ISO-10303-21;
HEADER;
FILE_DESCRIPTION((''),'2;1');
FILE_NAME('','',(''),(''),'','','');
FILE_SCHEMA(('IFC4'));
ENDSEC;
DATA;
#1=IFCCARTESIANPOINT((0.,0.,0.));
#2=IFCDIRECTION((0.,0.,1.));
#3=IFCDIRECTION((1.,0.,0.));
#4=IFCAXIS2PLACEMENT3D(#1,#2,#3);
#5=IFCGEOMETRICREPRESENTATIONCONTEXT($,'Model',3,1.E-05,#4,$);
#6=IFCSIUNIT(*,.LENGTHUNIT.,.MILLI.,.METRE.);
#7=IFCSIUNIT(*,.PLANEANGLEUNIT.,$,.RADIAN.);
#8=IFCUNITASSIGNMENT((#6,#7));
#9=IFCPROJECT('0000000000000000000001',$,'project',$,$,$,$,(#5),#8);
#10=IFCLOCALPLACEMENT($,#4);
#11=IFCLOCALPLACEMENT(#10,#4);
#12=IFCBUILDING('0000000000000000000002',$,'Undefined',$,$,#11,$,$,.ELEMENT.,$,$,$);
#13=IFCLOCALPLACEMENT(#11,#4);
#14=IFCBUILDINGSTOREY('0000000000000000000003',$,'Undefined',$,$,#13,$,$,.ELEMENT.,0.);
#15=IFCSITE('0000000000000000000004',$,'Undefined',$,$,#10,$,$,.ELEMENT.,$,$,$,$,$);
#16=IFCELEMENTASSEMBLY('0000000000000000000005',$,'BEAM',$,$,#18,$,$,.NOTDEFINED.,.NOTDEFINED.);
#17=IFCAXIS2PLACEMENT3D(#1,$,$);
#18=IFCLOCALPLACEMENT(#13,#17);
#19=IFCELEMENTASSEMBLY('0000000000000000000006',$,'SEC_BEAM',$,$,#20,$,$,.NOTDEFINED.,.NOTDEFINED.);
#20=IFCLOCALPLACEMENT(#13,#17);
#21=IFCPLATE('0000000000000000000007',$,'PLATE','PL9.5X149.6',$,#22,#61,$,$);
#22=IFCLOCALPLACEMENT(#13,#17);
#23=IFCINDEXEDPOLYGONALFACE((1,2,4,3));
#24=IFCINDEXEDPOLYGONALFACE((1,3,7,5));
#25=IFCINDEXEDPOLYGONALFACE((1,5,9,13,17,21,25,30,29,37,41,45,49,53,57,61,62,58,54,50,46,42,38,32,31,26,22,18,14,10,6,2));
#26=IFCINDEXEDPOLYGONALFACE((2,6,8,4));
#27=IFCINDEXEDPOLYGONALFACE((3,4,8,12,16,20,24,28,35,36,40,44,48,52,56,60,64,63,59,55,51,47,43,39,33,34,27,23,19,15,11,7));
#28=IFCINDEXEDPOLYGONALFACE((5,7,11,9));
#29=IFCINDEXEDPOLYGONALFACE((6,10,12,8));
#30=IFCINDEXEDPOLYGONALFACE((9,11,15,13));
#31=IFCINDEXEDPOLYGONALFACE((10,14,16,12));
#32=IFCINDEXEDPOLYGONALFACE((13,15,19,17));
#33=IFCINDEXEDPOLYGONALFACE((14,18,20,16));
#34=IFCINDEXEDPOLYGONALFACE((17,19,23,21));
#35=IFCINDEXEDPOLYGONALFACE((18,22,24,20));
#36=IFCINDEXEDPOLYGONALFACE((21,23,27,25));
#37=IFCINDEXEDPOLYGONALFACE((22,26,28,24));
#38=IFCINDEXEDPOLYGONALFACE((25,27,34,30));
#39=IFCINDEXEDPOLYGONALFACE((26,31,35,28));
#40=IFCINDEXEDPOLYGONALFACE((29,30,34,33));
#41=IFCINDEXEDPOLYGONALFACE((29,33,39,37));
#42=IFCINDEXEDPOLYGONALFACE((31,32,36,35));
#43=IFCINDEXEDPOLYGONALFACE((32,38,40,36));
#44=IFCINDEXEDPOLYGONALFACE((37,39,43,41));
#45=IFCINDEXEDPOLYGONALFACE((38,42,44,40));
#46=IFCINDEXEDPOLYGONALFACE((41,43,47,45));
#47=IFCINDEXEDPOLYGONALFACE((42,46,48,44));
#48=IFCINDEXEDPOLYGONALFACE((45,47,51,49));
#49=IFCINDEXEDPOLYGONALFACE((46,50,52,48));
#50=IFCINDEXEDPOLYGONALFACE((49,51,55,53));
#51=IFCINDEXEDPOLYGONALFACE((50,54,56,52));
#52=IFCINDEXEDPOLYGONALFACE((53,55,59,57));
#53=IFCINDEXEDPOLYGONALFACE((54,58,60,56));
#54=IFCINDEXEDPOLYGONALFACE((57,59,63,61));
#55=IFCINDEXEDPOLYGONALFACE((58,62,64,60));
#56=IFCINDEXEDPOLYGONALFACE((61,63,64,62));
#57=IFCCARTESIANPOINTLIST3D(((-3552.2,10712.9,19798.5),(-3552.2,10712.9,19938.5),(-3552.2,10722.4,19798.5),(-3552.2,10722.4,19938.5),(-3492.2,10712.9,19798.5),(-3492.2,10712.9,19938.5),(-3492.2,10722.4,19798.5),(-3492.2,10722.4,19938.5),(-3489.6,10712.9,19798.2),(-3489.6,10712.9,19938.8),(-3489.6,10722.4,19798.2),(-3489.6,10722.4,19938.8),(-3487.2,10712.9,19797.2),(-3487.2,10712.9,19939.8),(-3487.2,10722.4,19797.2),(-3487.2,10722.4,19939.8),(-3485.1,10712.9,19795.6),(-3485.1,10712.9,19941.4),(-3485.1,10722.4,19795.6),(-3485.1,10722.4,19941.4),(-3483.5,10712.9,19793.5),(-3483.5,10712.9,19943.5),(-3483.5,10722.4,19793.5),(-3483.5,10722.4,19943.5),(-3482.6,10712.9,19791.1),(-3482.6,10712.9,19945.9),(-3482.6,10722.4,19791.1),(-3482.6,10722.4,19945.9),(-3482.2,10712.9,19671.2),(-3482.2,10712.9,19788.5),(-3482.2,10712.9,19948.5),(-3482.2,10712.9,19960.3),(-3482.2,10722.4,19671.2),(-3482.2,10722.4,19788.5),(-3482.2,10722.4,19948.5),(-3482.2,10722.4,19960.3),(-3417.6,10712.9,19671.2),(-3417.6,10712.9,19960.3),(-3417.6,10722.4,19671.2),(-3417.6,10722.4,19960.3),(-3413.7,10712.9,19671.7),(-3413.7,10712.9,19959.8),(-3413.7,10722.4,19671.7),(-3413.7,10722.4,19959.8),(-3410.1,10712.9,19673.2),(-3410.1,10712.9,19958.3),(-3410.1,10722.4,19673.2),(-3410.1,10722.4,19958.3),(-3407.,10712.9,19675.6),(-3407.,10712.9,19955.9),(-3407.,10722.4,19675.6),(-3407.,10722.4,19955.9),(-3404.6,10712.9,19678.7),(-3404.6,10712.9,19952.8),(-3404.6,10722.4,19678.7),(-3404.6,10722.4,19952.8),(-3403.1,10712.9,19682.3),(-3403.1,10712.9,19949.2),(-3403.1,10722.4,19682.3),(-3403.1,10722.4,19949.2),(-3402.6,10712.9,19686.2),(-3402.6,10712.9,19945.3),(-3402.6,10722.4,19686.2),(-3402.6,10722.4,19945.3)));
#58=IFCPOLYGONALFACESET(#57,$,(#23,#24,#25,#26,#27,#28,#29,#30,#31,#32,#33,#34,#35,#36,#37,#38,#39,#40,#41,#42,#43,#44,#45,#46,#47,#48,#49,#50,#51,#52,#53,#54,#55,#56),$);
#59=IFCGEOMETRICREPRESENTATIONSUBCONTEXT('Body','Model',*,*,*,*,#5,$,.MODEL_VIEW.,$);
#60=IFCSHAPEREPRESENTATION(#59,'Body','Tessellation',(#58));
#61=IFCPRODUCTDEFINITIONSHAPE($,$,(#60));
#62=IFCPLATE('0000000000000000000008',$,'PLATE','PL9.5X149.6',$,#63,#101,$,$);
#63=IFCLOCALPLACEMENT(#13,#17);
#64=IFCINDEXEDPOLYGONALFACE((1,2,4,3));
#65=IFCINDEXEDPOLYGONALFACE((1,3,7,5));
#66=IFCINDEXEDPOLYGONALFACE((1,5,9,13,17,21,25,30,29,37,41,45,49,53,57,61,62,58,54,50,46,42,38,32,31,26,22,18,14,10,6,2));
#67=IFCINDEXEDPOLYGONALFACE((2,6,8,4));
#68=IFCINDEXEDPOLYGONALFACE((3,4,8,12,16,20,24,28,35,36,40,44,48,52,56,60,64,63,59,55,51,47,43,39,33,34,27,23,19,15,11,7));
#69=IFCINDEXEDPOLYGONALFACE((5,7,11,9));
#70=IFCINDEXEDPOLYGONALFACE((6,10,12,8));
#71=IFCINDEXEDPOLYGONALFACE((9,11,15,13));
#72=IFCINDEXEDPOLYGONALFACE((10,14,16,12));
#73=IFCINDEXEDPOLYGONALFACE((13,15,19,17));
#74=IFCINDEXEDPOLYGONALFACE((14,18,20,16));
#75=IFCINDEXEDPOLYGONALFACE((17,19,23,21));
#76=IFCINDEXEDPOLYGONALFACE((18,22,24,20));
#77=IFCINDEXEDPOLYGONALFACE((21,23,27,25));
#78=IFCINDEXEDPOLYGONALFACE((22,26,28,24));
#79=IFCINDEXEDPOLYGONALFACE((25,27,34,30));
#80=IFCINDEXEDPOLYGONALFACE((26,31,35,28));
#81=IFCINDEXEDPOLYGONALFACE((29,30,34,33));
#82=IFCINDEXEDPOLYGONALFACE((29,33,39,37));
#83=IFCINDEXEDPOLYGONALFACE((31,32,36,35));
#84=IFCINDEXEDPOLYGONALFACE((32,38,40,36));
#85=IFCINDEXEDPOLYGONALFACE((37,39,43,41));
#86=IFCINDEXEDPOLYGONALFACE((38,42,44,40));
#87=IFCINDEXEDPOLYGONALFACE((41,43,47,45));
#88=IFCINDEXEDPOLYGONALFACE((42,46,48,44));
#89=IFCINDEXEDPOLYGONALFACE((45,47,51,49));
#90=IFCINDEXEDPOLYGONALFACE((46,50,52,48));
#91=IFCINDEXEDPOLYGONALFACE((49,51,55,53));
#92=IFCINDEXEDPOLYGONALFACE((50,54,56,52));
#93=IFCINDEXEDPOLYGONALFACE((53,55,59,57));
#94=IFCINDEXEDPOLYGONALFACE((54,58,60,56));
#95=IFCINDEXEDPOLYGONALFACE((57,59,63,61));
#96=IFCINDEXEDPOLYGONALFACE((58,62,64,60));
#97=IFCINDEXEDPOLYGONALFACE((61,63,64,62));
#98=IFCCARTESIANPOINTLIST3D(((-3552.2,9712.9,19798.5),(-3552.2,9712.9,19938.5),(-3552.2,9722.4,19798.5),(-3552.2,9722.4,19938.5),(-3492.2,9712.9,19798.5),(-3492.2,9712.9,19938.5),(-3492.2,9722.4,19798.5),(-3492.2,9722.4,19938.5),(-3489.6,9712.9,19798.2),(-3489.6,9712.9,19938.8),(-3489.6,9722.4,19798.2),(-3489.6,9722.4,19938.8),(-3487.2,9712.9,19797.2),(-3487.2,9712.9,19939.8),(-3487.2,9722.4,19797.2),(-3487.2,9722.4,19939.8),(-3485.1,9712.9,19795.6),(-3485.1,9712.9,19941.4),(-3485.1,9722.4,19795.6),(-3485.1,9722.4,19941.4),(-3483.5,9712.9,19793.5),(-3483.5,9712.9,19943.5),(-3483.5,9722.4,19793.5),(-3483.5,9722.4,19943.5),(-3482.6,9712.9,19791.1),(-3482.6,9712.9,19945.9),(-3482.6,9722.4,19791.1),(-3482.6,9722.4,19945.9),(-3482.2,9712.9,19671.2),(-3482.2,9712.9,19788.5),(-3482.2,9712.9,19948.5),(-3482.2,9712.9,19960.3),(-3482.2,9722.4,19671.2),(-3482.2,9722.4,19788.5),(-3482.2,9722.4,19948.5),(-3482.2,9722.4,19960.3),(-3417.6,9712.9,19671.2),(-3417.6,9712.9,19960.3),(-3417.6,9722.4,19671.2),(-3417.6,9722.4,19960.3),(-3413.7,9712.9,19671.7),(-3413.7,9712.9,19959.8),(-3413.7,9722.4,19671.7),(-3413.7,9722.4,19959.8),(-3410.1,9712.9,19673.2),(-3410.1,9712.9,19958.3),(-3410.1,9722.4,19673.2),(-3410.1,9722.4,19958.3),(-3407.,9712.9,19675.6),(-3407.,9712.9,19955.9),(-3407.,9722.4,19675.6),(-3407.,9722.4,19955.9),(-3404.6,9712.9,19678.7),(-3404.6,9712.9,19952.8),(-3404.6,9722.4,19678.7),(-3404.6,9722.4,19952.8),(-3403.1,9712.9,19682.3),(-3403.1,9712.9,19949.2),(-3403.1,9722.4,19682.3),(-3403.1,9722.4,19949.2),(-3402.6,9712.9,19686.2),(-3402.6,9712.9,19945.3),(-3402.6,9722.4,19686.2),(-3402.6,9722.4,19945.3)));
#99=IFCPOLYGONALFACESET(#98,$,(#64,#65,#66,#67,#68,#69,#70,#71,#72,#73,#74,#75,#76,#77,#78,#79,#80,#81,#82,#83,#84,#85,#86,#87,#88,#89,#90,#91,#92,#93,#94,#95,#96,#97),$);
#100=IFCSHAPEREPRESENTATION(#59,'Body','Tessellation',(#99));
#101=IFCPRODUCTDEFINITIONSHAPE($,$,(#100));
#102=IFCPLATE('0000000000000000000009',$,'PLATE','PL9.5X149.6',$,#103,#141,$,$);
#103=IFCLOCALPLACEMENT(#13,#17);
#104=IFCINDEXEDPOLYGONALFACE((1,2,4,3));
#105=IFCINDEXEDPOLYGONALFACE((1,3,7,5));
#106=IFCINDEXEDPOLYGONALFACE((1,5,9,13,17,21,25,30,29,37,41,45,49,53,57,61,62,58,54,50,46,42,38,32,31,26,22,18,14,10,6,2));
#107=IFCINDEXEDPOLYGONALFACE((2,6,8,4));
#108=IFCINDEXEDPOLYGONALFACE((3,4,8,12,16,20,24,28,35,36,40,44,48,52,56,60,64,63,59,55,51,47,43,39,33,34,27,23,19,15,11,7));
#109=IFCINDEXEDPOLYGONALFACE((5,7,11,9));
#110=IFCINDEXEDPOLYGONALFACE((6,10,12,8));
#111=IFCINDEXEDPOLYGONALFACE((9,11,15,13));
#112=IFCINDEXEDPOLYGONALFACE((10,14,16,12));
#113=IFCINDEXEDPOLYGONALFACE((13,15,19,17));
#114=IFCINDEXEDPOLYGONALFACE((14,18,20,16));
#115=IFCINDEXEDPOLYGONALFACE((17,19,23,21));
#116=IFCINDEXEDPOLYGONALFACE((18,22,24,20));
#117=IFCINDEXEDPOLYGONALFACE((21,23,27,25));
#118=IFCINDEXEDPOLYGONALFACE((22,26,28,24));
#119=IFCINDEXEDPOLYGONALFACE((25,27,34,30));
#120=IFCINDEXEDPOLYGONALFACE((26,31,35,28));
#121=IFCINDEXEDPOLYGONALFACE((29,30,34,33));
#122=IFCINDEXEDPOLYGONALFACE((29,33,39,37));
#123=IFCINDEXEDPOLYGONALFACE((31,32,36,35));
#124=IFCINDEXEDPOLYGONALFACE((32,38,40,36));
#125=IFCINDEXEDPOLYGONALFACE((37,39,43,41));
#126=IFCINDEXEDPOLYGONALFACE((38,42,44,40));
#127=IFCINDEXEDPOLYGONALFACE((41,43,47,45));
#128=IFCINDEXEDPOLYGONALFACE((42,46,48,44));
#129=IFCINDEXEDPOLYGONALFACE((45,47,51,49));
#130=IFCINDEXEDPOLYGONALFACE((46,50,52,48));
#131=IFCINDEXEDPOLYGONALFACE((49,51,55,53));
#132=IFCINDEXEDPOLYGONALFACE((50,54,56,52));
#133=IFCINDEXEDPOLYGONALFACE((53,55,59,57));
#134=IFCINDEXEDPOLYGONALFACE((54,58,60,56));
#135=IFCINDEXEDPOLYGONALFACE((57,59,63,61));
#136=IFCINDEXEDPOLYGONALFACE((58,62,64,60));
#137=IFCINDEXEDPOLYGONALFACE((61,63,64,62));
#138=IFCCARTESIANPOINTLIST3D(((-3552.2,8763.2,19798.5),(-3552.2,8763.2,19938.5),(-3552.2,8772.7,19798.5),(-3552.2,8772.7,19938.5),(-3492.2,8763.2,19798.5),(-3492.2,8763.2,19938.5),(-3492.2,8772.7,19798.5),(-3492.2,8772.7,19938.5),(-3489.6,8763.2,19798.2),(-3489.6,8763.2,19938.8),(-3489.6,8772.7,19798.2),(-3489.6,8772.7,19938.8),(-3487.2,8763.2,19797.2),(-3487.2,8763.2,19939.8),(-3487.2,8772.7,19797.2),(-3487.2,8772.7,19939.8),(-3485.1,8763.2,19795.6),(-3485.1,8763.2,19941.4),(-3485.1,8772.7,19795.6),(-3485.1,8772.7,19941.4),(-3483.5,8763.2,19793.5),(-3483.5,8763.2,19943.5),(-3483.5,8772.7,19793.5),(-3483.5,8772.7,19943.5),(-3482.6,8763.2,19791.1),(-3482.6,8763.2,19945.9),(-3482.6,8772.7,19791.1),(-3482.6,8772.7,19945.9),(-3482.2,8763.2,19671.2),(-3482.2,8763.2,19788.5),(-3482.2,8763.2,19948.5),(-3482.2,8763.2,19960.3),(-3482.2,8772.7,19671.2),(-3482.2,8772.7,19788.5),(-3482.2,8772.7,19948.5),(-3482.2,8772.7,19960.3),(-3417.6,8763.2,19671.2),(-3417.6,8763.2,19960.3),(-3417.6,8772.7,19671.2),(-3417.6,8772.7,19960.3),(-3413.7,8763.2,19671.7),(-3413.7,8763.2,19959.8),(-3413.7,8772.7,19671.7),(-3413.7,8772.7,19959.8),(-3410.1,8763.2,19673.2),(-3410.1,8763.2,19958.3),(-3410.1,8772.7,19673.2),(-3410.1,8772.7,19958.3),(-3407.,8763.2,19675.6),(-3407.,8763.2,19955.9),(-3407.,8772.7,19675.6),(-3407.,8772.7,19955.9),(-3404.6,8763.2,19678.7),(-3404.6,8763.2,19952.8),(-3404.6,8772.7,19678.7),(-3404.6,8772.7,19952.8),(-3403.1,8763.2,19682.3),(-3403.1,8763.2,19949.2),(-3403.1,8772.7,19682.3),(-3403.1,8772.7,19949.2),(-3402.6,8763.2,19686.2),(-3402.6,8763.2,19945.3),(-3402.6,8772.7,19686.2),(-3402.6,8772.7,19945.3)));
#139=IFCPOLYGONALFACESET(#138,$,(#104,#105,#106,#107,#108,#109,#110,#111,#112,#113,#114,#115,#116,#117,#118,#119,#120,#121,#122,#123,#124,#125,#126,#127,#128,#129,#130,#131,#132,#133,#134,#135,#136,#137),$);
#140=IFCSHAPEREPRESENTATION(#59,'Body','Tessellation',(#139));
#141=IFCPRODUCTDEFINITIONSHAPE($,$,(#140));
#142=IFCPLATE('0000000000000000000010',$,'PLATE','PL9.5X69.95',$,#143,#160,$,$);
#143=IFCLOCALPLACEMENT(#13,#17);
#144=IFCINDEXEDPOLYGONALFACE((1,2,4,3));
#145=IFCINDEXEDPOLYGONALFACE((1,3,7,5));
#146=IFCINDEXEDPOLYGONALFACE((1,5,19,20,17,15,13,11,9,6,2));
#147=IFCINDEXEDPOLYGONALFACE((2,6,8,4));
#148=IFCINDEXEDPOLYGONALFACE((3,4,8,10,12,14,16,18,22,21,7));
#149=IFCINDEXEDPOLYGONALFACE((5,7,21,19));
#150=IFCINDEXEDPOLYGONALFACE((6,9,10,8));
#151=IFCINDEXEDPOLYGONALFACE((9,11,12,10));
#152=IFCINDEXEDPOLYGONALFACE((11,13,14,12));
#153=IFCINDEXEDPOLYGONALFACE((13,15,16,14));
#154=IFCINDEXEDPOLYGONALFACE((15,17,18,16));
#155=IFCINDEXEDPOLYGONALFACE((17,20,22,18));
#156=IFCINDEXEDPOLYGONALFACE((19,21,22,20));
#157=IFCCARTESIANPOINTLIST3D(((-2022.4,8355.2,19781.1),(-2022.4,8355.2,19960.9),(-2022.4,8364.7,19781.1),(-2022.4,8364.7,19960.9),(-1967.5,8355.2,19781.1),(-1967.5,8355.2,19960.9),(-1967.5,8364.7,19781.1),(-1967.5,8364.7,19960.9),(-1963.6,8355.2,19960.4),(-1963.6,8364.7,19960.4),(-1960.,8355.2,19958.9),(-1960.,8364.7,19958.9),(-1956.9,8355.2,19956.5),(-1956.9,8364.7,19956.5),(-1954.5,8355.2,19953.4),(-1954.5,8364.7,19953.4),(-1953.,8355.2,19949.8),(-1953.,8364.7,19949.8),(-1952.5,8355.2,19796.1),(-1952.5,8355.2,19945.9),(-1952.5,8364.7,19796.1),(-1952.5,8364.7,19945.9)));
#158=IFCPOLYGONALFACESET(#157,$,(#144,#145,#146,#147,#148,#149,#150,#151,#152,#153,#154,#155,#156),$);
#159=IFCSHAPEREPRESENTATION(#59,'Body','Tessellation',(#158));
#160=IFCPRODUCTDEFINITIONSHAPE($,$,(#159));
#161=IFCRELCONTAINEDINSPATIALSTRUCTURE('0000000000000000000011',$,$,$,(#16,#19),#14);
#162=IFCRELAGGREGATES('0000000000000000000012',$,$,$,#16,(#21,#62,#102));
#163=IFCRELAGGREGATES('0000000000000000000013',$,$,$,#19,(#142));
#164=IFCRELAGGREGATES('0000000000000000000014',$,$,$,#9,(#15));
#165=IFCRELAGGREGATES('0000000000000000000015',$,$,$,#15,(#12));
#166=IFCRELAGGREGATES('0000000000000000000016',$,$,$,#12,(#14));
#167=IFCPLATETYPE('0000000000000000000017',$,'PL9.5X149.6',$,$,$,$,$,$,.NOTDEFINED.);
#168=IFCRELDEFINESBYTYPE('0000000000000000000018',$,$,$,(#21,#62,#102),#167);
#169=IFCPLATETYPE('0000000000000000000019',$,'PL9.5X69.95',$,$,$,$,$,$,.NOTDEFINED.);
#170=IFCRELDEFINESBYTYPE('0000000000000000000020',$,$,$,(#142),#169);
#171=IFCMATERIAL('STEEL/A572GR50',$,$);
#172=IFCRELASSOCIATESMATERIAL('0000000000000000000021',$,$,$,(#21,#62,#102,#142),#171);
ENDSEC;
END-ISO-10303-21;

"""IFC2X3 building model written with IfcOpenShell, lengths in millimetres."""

from ifc_helpers import new_model, si_unit, frame, frame_2d, origin_with_axes, place, context, subcontext, project, spatial, polyline, circle_curve, parameter, trimmed, segment, composite_curve, outline, extrude, material, type_object, element, aggregate, save


model = new_model("IFC2X3")

# Units and contexts
model_context = context("Model", 3, precision=1e-05, world=origin_with_axes())
body_context = subcontext(model_context, "Body", "Model", "MODEL_VIEW")
ifc_project = project(units=[si_unit("LENGTHUNIT", "METRE", prefix="MILLI"), si_unit("PLANEANGLEUNIT", "RADIAN")], contexts=[model_context])

# Site, building, storey
site_placement = place(None, origin_with_axes())
site = spatial("IfcSite", under=ifc_project, at=site_placement, Name="Undefined", CompositionType="ELEMENT")
building_placement = place(site_placement, origin_with_axes())
building = spatial("IfcBuilding", under=site, at=building_placement, Name="Undefined", CompositionType="ELEMENT")
storey_placement = place(building_placement, origin_with_axes())
storey = spatial("IfcBuildingStorey", under=building, at=storey_placement, Name="Undefined", CompositionType="ELEMENT", Elevation=0.0)

# Element assemblies
assembly_1_placement = place(storey_placement, origin_with_axes())
assembly_1 = element("IfcElementAssembly", 1, at=assembly_1_placement, inside=storey, Name="BEAM", AssemblyPlace="NOTDEFINED", PredefinedType="NOTDEFINED")
ifc_material_1 = material(Name="STEEL/A572GR50")
assembly_2_placement = place(storey_placement, origin_with_axes())
assembly_2 = element("IfcElementAssembly", 2, at=assembly_2_placement, inside=storey, Name="SEC_BEAM", AssemblyPlace="NOTDEFINED", PredefinedType="NOTDEFINED")

# Plates
plate_type_1 = type_object("IfcPlateType", Name="PL9.5X149.6", PredefinedType="NOTDEFINED")
plate_1_placement = place(assembly_1_placement, frame((-3402.6, 10717.7, 19960.3), z_axis=(0.0, 1.0, 0.0), x_axis=(0.0, 0.0, -1.0)))
plate_1 = element("IfcPlate", 3, at=plate_1_placement, type_object=plate_type_1, material=ifc_material_1, Name="PLATE", Description="PL9.5X149.6", context=body_context, shape_type="SweptSolid", body=[
    extrude(outline(composite_curve([segment(trimmed(circle_curve(frame_2d((15.0, 15.0), x_axis=(-1.0, 0.0)), 15.0), [parameter(0.0)], [parameter(1.570796)], True, "PARAMETER"), True, "CONTINUOUS"), segment(polyline([(15.0, 0.0), (274.1, 0.0)]), True, "CONTINUOUS"), segment(trimmed(circle_curve(frame_2d((274.1, 15.0), x_axis=(0.0, -1.0)), 15.0), [parameter(0.0)], [parameter(1.570796)], True, "PARAMETER"), True, "CONTINUOUS"), segment(polyline([(289.1, 15.0), (289.1, 79.6), (171.8, 79.6)]), True, "CONTINUOUS"), segment(trimmed(circle_curve(frame_2d((171.8, 89.6), x_axis=(0.0, -1.0)), 10.0), [parameter(0.0)], [parameter(4.712389)], False, "PARAMETER"), True, "CONTINUOUS"), segment(polyline([(161.8, 89.6), (161.8, 149.6), (21.8, 149.6), (21.8, 89.6)]), True, "CONTINUOUS"), segment(trimmed(circle_curve(frame_2d((11.8, 89.6), x_axis=(1.0, 0.0)), 10.0), [parameter(0.0)], [parameter(4.712389)], False, "PARAMETER"), True, "CONTINUOUS"), segment(polyline([(11.8, 79.6), (0.0, 79.6), (0.0, 15.0)]), True, "CONTINUOUS")], self_intersect=True)), frame((0.0, 0.0, -4.8), z_axis=(0.0, 0.0, 1.0), x_axis=(1.0, 0.0, 0.0)), (0.0, 0.0, 1.0), 9.5),
])
plate_2_placement = place(assembly_1_placement, frame((-3402.6, 9717.7, 19960.3), z_axis=(0.0, 1.0, 0.0), x_axis=(0.0, 0.0, -1.0)))
plate_2 = element("IfcPlate", 4, at=plate_2_placement, type_object=plate_type_1, material=ifc_material_1, Name="PLATE", Description="PL9.5X149.6", context=body_context, shape_type="SweptSolid", body=[
    extrude(outline(composite_curve([segment(trimmed(circle_curve(frame_2d((15.0, 15.0), x_axis=(-1.0, 0.0)), 15.0), [parameter(0.0)], [parameter(1.570796)], True, "PARAMETER"), True, "CONTINUOUS"), segment(polyline([(15.0, 0.0), (274.1, 0.0)]), True, "CONTINUOUS"), segment(trimmed(circle_curve(frame_2d((274.1, 15.0), x_axis=(0.0, -1.0)), 15.0), [parameter(0.0)], [parameter(1.570796)], True, "PARAMETER"), True, "CONTINUOUS"), segment(polyline([(289.1, 15.0), (289.1, 79.6), (171.8, 79.6)]), True, "CONTINUOUS"), segment(trimmed(circle_curve(frame_2d((171.8, 89.6), x_axis=(0.0, -1.0)), 10.0), [parameter(0.0)], [parameter(4.712389)], False, "PARAMETER"), True, "CONTINUOUS"), segment(polyline([(161.8, 89.6), (161.8, 149.6), (21.8, 149.6), (21.8, 89.6)]), True, "CONTINUOUS"), segment(trimmed(circle_curve(frame_2d((11.8, 89.6), x_axis=(1.0, 0.0)), 10.0), [parameter(0.0)], [parameter(4.712389)], False, "PARAMETER"), True, "CONTINUOUS"), segment(polyline([(11.8, 79.6), (0.0, 79.6), (0.0, 15.0)]), True, "CONTINUOUS")], self_intersect=True)), frame((0.0, 0.0, -4.8), z_axis=(0.0, 0.0, 1.0), x_axis=(1.0, 0.0, 0.0)), (0.0, 0.0, 1.0), 9.5),
])
plate_3_placement = place(assembly_1_placement, frame((-3402.6, 8767.9, 19960.3), z_axis=(0.0, 1.0, 0.0), x_axis=(0.0, 0.0, -1.0)))
plate_3 = element("IfcPlate", 5, at=plate_3_placement, type_object=plate_type_1, material=ifc_material_1, Name="PLATE", Description="PL9.5X149.6", context=body_context, shape_type="SweptSolid", body=[
    extrude(outline(composite_curve([segment(trimmed(circle_curve(frame_2d((15.0, 15.0), x_axis=(-1.0, 0.0)), 15.0), [parameter(0.0)], [parameter(1.570796)], True, "PARAMETER"), True, "CONTINUOUS"), segment(polyline([(15.0, 0.0), (274.1, 0.0)]), True, "CONTINUOUS"), segment(trimmed(circle_curve(frame_2d((274.1, 15.0), x_axis=(0.0, -1.0)), 15.0), [parameter(0.0)], [parameter(1.570796)], True, "PARAMETER"), True, "CONTINUOUS"), segment(polyline([(289.1, 15.0), (289.1, 79.6), (171.8, 79.6)]), True, "CONTINUOUS"), segment(trimmed(circle_curve(frame_2d((171.8, 89.6), x_axis=(0.0, -1.0)), 10.0), [parameter(0.0)], [parameter(4.712389)], False, "PARAMETER"), True, "CONTINUOUS"), segment(polyline([(161.8, 89.6), (161.8, 149.6), (21.8, 149.6), (21.8, 89.6)]), True, "CONTINUOUS"), segment(trimmed(circle_curve(frame_2d((11.8, 89.6), x_axis=(1.0, 0.0)), 10.0), [parameter(0.0)], [parameter(4.712389)], False, "PARAMETER"), True, "CONTINUOUS"), segment(polyline([(11.8, 79.6), (0.0, 79.6), (0.0, 15.0)]), True, "CONTINUOUS")], self_intersect=True)), frame((0.0, 0.0, -4.8), z_axis=(0.0, 0.0, 1.0), x_axis=(1.0, 0.0, 0.0)), (0.0, 0.0, 1.0), 9.5),
])
plate_type_2 = type_object("IfcPlateType", Name="PL9.5X69.95", PredefinedType="NOTDEFINED")
plate_4_placement = place(assembly_2_placement, frame((-2022.4, 8360.0, 19781.1), z_axis=(0.0, -1.0, 0.0), x_axis=(1.0, 0.0, 0.0)))
plate_4 = element("IfcPlate", 6, at=plate_4_placement, type_object=plate_type_2, material=ifc_material_1, Name="PLATE", Description="PL9.5X69.95", context=body_context, shape_type="SweptSolid", body=[
    extrude(outline(composite_curve([segment(polyline([(0.0, 0.0), (54.9, 0.0), (69.9, 15.0), (69.9, 164.8)]), True, "CONTINUOUS"), segment(trimmed(circle_curve(frame_2d((54.9, 164.8), x_axis=(1.0, 0.0)), 15.0), [parameter(0.0)], [parameter(1.570796)], True, "PARAMETER"), True, "CONTINUOUS"), segment(polyline([(54.9, 179.8), (0.0, 179.8), (0.0, 0.0)]), True, "CONTINUOUS")], self_intersect=True)), frame((0.0, 0.0, -4.8), z_axis=(0.0, 0.0, 1.0), x_axis=(1.0, 0.0, 0.0)), (0.0, 0.0, 1.0), 9.5),
])

aggregate(assembly_1, [plate_1, plate_2, plate_3])

aggregate(assembly_2, [plate_4])

save(model, "model.ifc")
